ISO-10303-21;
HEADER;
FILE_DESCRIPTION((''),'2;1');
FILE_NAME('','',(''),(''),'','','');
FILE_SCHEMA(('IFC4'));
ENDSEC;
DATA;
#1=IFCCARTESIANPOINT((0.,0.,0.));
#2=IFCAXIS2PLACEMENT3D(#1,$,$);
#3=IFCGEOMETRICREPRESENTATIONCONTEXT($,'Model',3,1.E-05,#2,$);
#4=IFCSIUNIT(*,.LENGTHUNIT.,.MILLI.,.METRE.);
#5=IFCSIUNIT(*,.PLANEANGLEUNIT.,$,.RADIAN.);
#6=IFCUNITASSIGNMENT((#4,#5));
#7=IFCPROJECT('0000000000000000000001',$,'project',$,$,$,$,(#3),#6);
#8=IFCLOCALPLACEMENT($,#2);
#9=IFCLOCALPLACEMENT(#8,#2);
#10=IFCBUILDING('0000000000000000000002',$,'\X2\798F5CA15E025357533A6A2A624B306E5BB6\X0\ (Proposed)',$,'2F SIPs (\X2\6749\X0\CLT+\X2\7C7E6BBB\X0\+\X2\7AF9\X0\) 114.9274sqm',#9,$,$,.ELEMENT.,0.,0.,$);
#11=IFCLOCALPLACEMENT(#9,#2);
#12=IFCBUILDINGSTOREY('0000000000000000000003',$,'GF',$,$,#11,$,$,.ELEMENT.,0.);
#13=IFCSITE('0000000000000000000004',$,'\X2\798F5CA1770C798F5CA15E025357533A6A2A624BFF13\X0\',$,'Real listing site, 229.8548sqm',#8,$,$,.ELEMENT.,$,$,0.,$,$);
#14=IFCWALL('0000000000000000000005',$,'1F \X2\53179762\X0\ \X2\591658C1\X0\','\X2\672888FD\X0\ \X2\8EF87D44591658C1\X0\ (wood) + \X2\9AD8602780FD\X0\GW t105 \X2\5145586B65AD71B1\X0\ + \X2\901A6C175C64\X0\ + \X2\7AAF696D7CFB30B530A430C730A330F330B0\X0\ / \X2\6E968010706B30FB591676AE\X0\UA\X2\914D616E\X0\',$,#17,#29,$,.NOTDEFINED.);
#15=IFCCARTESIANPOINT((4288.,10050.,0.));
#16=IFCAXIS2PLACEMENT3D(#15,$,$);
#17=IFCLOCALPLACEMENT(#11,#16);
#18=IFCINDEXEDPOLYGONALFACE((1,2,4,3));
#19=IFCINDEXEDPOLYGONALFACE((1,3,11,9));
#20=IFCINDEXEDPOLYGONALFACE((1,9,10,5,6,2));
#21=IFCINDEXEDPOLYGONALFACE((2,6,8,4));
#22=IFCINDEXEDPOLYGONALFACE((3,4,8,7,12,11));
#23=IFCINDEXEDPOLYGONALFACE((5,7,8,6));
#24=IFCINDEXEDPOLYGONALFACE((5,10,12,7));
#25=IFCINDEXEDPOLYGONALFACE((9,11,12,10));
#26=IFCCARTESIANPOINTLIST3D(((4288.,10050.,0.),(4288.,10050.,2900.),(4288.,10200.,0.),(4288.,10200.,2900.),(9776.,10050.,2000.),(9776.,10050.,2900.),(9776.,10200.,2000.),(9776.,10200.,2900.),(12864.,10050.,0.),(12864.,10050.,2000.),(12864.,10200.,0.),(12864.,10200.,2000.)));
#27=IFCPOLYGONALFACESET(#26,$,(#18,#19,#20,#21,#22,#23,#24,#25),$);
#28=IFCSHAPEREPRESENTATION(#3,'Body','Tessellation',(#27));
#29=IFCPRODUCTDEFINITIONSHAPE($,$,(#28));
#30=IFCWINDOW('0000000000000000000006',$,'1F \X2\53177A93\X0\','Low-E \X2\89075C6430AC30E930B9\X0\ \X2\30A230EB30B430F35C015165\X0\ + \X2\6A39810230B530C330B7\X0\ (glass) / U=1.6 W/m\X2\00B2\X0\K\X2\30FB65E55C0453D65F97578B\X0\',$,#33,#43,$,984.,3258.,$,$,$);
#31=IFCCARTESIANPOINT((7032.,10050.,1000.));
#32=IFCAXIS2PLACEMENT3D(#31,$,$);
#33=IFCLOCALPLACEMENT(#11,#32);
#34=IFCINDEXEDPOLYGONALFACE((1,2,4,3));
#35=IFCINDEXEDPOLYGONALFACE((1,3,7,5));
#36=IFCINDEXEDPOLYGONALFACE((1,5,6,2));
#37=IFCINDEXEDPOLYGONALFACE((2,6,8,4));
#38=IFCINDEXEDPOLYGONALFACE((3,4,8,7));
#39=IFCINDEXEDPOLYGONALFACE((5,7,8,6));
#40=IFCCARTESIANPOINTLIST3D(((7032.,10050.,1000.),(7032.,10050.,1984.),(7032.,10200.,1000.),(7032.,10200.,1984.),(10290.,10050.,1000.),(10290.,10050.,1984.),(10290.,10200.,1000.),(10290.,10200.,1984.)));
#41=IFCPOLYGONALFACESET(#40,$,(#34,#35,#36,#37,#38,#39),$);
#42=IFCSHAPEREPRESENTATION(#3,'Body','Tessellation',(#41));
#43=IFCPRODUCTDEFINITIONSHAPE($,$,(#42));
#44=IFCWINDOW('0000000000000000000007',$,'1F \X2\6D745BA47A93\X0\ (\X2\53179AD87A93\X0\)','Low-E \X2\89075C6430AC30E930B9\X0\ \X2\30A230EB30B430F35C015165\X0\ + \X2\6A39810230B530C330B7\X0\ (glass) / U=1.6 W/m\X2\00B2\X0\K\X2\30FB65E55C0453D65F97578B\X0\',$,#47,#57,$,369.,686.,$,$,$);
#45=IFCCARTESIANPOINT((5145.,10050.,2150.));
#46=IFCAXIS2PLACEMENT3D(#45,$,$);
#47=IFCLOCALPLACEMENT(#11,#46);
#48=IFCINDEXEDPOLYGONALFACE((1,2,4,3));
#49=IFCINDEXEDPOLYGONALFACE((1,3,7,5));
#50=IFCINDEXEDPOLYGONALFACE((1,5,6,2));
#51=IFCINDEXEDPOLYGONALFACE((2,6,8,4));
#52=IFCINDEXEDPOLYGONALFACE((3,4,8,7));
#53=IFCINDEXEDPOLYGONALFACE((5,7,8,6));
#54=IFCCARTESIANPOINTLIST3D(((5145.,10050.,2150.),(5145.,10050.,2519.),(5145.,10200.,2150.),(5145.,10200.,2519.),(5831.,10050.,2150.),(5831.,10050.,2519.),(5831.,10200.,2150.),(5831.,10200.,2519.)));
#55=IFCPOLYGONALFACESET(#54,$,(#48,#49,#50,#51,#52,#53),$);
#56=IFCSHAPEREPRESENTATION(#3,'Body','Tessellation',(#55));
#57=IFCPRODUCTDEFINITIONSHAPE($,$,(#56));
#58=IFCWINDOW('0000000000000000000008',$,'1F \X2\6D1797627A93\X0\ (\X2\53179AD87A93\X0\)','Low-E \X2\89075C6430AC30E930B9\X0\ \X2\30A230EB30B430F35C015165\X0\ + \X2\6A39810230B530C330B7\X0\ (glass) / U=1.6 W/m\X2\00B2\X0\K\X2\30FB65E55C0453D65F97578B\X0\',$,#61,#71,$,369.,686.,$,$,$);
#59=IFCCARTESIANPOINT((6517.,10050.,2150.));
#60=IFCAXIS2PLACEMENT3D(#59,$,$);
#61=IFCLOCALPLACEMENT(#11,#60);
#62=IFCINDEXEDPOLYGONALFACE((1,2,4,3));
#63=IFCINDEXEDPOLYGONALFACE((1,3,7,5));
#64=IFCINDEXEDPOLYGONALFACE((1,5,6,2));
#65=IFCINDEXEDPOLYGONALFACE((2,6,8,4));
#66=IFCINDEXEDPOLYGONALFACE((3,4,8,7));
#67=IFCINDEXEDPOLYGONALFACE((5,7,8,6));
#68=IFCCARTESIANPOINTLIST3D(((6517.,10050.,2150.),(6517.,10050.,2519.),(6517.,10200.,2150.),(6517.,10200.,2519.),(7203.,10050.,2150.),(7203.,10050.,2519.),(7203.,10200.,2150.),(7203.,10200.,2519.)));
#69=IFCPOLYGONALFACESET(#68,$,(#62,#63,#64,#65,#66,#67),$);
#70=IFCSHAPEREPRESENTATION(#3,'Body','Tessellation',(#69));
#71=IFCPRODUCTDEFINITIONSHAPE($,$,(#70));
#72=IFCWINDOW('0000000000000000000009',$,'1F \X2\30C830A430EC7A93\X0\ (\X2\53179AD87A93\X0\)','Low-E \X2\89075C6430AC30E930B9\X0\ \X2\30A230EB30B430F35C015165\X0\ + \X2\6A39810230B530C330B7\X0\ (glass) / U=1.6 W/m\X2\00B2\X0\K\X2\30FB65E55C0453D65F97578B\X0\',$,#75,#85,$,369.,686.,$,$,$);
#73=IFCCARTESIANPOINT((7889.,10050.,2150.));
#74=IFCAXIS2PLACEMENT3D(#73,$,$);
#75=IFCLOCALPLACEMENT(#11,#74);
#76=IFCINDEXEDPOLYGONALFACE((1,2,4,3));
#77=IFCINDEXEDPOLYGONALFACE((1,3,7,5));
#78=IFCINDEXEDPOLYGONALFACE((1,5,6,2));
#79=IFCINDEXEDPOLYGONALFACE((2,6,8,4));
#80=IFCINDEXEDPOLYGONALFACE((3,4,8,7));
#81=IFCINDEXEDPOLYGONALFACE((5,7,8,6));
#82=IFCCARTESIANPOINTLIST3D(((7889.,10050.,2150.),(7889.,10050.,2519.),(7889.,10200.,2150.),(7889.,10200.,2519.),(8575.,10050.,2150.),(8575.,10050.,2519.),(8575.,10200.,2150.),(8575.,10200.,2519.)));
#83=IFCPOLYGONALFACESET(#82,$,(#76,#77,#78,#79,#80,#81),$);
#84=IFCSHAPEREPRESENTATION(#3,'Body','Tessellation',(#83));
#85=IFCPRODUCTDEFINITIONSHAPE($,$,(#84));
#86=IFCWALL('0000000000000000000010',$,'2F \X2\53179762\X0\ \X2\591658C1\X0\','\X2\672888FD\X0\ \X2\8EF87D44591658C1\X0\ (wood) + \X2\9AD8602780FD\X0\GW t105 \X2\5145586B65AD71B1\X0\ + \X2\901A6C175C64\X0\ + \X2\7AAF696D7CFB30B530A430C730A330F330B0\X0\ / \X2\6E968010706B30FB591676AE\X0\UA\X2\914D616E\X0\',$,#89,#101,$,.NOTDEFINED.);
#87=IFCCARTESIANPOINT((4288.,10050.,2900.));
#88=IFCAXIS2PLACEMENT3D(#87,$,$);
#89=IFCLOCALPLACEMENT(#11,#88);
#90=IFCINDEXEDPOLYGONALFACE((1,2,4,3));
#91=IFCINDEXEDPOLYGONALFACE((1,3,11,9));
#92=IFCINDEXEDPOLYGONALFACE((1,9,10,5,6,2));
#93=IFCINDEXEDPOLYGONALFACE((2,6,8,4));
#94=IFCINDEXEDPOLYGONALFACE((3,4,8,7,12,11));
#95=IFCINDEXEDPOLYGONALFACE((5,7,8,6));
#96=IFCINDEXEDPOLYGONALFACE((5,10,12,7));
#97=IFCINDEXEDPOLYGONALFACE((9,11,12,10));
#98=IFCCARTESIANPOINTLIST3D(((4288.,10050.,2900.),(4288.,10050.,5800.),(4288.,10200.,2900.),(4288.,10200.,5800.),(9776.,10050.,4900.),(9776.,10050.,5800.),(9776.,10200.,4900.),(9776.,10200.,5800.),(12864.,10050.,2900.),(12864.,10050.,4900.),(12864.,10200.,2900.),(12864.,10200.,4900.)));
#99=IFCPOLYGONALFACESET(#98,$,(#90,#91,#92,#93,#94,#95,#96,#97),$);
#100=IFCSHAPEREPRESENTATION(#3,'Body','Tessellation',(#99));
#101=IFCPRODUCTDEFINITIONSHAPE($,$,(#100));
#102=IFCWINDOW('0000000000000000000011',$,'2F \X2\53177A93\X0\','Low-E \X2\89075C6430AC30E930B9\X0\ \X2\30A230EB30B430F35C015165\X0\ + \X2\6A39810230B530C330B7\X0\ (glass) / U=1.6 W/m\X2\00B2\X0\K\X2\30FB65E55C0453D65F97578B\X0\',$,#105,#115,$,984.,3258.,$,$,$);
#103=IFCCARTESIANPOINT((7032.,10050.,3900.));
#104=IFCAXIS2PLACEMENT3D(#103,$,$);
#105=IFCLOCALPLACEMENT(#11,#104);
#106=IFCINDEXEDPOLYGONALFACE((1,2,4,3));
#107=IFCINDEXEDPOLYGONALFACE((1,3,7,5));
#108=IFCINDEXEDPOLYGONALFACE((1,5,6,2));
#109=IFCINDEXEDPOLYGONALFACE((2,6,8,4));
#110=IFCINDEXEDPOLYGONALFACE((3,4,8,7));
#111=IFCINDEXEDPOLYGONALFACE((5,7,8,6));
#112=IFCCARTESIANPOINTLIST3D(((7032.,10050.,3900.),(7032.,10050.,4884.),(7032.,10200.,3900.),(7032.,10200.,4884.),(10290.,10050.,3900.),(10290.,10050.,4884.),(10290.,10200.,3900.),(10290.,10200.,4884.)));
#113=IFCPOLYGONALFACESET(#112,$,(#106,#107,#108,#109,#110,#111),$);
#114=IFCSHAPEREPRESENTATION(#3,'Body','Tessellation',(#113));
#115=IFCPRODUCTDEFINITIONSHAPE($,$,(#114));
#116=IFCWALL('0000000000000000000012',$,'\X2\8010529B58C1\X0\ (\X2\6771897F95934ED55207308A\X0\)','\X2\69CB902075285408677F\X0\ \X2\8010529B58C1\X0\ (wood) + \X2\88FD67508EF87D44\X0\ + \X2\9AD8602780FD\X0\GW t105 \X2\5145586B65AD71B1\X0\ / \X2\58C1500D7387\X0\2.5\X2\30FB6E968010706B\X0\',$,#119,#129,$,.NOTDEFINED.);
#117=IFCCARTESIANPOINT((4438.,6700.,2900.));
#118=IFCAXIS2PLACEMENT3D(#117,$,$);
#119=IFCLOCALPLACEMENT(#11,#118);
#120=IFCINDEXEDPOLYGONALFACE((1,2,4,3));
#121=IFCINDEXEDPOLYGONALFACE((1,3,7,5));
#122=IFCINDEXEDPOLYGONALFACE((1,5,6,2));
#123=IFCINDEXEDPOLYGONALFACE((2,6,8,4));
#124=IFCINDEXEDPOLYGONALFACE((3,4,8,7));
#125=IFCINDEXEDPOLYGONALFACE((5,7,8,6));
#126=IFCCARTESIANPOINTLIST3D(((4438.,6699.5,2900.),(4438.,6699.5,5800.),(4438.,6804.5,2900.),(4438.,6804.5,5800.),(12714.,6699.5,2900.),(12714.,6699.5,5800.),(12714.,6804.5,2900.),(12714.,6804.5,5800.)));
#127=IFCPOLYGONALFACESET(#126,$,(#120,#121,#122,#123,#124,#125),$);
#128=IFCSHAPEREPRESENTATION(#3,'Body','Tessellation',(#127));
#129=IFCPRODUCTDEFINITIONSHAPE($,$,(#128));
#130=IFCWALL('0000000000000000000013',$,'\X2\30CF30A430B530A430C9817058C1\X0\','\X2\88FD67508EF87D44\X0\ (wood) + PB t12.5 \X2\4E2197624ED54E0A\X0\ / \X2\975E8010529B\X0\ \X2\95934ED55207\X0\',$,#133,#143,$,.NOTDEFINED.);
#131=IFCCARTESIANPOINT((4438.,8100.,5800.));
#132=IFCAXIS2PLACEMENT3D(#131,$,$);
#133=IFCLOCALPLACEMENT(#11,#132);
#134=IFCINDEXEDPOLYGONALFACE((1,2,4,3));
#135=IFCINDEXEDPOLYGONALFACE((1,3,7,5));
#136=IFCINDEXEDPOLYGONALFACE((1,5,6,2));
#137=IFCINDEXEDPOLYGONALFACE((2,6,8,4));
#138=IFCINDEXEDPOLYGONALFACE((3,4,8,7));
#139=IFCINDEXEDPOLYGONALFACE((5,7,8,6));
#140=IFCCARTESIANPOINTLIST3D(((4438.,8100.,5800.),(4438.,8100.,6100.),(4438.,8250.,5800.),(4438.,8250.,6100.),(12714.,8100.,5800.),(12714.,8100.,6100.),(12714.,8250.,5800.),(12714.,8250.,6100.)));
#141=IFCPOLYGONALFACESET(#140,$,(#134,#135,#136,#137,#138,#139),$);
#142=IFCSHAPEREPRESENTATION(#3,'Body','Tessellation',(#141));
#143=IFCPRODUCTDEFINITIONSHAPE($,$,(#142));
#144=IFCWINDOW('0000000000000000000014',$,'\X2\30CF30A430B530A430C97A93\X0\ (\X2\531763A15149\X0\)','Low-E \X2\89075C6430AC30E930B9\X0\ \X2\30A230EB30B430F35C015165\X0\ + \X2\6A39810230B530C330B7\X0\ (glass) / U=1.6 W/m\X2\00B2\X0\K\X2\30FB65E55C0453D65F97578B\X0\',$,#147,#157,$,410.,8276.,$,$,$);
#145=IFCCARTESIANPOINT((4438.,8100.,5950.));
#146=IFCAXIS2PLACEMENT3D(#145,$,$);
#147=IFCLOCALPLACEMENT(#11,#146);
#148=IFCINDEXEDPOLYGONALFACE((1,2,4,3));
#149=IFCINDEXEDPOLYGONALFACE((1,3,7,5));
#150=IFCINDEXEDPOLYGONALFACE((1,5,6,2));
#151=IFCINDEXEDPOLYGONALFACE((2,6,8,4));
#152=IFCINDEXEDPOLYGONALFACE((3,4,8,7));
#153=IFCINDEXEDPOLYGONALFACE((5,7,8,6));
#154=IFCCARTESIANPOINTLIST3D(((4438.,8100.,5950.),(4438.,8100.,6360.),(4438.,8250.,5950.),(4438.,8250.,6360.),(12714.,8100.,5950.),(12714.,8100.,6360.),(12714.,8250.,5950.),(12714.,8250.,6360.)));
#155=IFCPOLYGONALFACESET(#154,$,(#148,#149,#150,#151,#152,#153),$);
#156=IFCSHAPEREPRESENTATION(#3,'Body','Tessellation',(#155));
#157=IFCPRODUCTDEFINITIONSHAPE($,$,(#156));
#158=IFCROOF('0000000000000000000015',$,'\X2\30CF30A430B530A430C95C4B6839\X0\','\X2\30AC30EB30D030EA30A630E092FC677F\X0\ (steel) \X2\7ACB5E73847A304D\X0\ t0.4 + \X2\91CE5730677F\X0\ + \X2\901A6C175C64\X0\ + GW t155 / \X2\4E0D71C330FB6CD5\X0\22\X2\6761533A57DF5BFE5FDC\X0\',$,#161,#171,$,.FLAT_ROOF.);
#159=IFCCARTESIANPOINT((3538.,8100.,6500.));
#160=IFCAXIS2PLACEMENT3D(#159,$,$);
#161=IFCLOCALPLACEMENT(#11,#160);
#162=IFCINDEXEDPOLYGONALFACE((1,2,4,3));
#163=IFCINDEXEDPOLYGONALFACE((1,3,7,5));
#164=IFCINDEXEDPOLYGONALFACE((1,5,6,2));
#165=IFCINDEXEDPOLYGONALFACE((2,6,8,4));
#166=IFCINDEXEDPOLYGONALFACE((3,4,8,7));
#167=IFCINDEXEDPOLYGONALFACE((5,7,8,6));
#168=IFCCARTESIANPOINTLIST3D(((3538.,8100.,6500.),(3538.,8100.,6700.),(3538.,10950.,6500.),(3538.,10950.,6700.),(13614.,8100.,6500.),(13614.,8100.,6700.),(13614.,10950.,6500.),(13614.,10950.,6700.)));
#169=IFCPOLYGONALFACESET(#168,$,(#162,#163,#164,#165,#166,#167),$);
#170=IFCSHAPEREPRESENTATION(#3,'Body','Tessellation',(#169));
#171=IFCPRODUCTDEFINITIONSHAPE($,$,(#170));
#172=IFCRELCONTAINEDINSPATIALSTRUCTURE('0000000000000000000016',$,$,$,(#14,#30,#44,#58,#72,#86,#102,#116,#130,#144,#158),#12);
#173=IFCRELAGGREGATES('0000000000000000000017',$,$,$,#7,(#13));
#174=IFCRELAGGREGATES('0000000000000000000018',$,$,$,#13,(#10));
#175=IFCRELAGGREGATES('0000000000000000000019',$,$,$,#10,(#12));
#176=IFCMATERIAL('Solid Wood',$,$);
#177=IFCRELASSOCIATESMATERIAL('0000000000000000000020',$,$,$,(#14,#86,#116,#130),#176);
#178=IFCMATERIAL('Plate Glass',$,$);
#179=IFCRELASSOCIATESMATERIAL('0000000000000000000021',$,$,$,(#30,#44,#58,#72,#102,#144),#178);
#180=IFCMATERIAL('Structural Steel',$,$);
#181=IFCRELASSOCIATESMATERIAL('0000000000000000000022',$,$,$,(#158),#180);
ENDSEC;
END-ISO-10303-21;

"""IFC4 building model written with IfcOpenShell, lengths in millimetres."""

from ifc_helpers import new_model, si_unit, frame, frame_2d, origin, place, context, project, spatial, rectangle, extrude, material, element, fill, save


model = new_model("IFC4")

# Units and contexts
model_context = context("Model", 3, precision=1e-05, world=origin())
ifc_project = project(units=[si_unit("LENGTHUNIT", "METRE", prefix="MILLI"), si_unit("PLANEANGLEUNIT", "RADIAN")], contexts=[model_context])

# Site, building, storey
site_placement = place(None, origin())
site = spatial("IfcSite", under=ifc_project, at=site_placement, Name="福岡県福岡市南区横手３", ObjectType="Real listing site, 229.8548sqm", CompositionType="ELEMENT", RefElevation=0.0)
building_placement = place(site_placement, origin())
building = spatial("IfcBuilding", under=site, at=building_placement, Name="福岡市南区横手の家 (Proposed)", ObjectType="2F SIPs (杉CLT+籾殻+竹) 114.9274sqm", CompositionType="ELEMENT", ElevationOfRefHeight=0.0, ElevationOfTerrain=0.0)
storey_placement = place(building_placement, origin())
storey = spatial("IfcBuildingStorey", under=building, at=storey_placement, Name="GF", CompositionType="ELEMENT", Elevation=0.0)

# Wall, openings, windows
ifc_material_1 = material(Name="Solid Wood")
wall_1_placement = place(storey_placement, frame((4288.0, 10050.0, 0.0)))
wall_1 = element("IfcWall", 1, at=wall_1_placement, inside=storey, material=ifc_material_1, Name="1F 北面 外壁", Description="木製 軸組外壁 (wood) + 高性能GW t105 充填断熱 + 通気層 + 窯業系サイディング / 準耐火・外皮UA配慮", PredefinedType="NOTDEFINED", context=model_context, shape_type="SweptSolid", body=[
    extrude(rectangle(XDim=8576.0, YDim=150.0, at=frame_2d((4288.0, 75.0))), frame((4288.0, 10050.0, 0.0)), (0.0, 0.0, 1.0), 2900.0),
])
opening_1_placement = place(storey_placement, frame((7032.0, 10050.0, 1000.0)))
opening_1 = element("IfcOpeningElement", 2, at=opening_1_placement, cuts=wall_1, PredefinedType="NOTDEFINED", context=model_context, shape_type="SweptSolid", body=[
    extrude(rectangle(XDim=3258.0, YDim=150.0, at=frame_2d((1629.0, 75.0))), frame((7032.0, 10050.0, 1000.0)), (0.0, 0.0, 1.0), 984.0),
])
opening_2_placement = place(storey_placement, frame((5145.0, 10050.0, 2150.0)))
opening_2 = element("IfcOpeningElement", 3, at=opening_2_placement, cuts=wall_1, PredefinedType="NOTDEFINED", context=model_context, shape_type="SweptSolid", body=[
    extrude(rectangle(XDim=686.0, YDim=150.0, at=frame_2d((343.0, 75.0))), frame((5145.0, 10050.0, 2150.0)), (0.0, 0.0, 1.0), 369.0),
])
opening_3_placement = place(storey_placement, frame((6517.0, 10050.0, 2150.0)))
opening_3 = element("IfcOpeningElement", 4, at=opening_3_placement, cuts=wall_1, PredefinedType="NOTDEFINED", context=model_context, shape_type="SweptSolid", body=[
    extrude(rectangle(XDim=686.0, YDim=150.0, at=frame_2d((343.0, 75.0))), frame((6517.0, 10050.0, 2150.0)), (0.0, 0.0, 1.0), 369.0),
])
opening_4_placement = place(storey_placement, frame((7889.0, 10050.0, 2150.0)))
opening_4 = element("IfcOpeningElement", 5, at=opening_4_placement, cuts=wall_1, PredefinedType="NOTDEFINED", context=model_context, shape_type="SweptSolid", body=[
    extrude(rectangle(XDim=686.0, YDim=150.0, at=frame_2d((343.0, 75.0))), frame((7889.0, 10050.0, 2150.0)), (0.0, 0.0, 1.0), 369.0),
])
ifc_material_2 = material(Name="Plate Glass")
window_1_placement = place(storey_placement, frame((7032.0, 10050.0, 1000.0)))
window_1 = element("IfcWindow", 6, at=window_1_placement, inside=storey, material=ifc_material_2, Name="1F 北窓", Description="Low-E 複層ガラス アルゴン封入 + 樹脂サッシ (glass) / U=1.6 W/m²K・日射取得型", OverallHeight=984.0, OverallWidth=3258.0, context=model_context, shape_type="SweptSolid", body=[
    extrude(rectangle(XDim=3258.0, YDim=150.0, at=frame_2d((1629.0, 75.0))), frame((7032.0, 10050.0, 1000.0)), (0.0, 0.0, 1.0), 984.0),
])
fill(opening_1, window_1)
window_2_placement = place(storey_placement, frame((5145.0, 10050.0, 2150.0)))
window_2 = element("IfcWindow", 7, at=window_2_placement, inside=storey, material=ifc_material_2, Name="1F 浴室窓 (北高窓)", Description="Low-E 複層ガラス アルゴン封入 + 樹脂サッシ (glass) / U=1.6 W/m²K・日射取得型", OverallHeight=369.0, OverallWidth=686.0, context=model_context, shape_type="SweptSolid", body=[
    extrude(rectangle(XDim=686.0, YDim=150.0, at=frame_2d((343.0, 75.0))), frame((5145.0, 10050.0, 2150.0)), (0.0, 0.0, 1.0), 369.0),
])
fill(opening_2, window_2)
window_3_placement = place(storey_placement, frame((6517.0, 10050.0, 2150.0)))
window_3 = element("IfcWindow", 8, at=window_3_placement, inside=storey, material=ifc_material_2, Name="1F 洗面窓 (北高窓)", Description="Low-E 複層ガラス アルゴン封入 + 樹脂サッシ (glass) / U=1.6 W/m²K・日射取得型", OverallHeight=369.0, OverallWidth=686.0, context=model_context, shape_type="SweptSolid", body=[
    extrude(rectangle(XDim=686.0, YDim=150.0, at=frame_2d((343.0, 75.0))), frame((6517.0, 10050.0, 2150.0)), (0.0, 0.0, 1.0), 369.0),
])
fill(opening_3, window_3)
window_4_placement = place(storey_placement, frame((7889.0, 10050.0, 2150.0)))
window_4 = element("IfcWindow", 9, at=window_4_placement, inside=storey, material=ifc_material_2, Name="1F トイレ窓 (北高窓)", Description="Low-E 複層ガラス アルゴン封入 + 樹脂サッシ (glass) / U=1.6 W/m²K・日射取得型", OverallHeight=369.0, OverallWidth=686.0, context=model_context, shape_type="SweptSolid", body=[
    extrude(rectangle(XDim=686.0, YDim=150.0, at=frame_2d((343.0, 75.0))), frame((7889.0, 10050.0, 2150.0)), (0.0, 0.0, 1.0), 369.0),
])
fill(opening_4, window_4)

# Wall, opening, window
wall_2_placement = place(storey_placement, frame((4288.0, 10050.0, 2900.0)))
wall_2 = element("IfcWall", 10, at=wall_2_placement, inside=storey, material=ifc_material_1, Name="2F 北面 外壁", Description="木製 軸組外壁 (wood) + 高性能GW t105 充填断熱 + 通気層 + 窯業系サイディング / 準耐火・外皮UA配慮", PredefinedType="NOTDEFINED", context=model_context, shape_type="SweptSolid", body=[
    extrude(rectangle(XDim=8576.0, YDim=150.0, at=frame_2d((4288.0, 75.0))), frame((4288.0, 10050.0, 2900.0)), (0.0, 0.0, 1.0), 2900.0),
])
opening_5_placement = place(storey_placement, frame((7032.0, 10050.0, 3900.0)))
opening_5 = element("IfcOpeningElement", 11, at=opening_5_placement, cuts=wall_2, PredefinedType="NOTDEFINED", context=model_context, shape_type="SweptSolid", body=[
    extrude(rectangle(XDim=3258.0, YDim=150.0, at=frame_2d((1629.0, 75.0))), frame((7032.0, 10050.0, 3900.0)), (0.0, 0.0, 1.0), 984.0),
])
window_5_placement = place(storey_placement, frame((7032.0, 10050.0, 3900.0)))
window_5 = element("IfcWindow", 12, at=window_5_placement, inside=storey, material=ifc_material_2, Name="2F 北窓", Description="Low-E 複層ガラス アルゴン封入 + 樹脂サッシ (glass) / U=1.6 W/m²K・日射取得型", OverallHeight=984.0, OverallWidth=3258.0, context=model_context, shape_type="SweptSolid", body=[
    extrude(rectangle(XDim=3258.0, YDim=150.0, at=frame_2d((1629.0, 75.0))), frame((7032.0, 10050.0, 3900.0)), (0.0, 0.0, 1.0), 984.0),
])
fill(opening_5, window_5)

# Wall
wall_3_placement = place(storey_placement, frame((4438.0, 6700.0, 2900.0)))
element("IfcWall", 13, at=wall_3_placement, inside=storey, material=ifc_material_1, Name="耐力壁 (東西間仕切り)", Description="構造用合板 耐力壁 (wood) + 製材軸組 + 高性能GW t105 充填断熱 / 壁倍率2.5・準耐火", PredefinedType="NOTDEFINED", context=model_context, shape_type="SweptSolid", body=[
    extrude(rectangle(XDim=8276.0, YDim=105.0, at=frame_2d((4138.0, 52.0))), frame((4438.0, 6700.0, 2900.0)), (0.0, 0.0, 1.0), 2900.0),
])

# Wall, opening, window
wall_4_placement = place(storey_placement, frame((4438.0, 8100.0, 5800.0)))
wall_4 = element("IfcWall", 14, at=wall_4_placement, inside=storey, material=ifc_material_1, Name="ハイサイド腰壁", Description="製材軸組 (wood) + PB t12.5 両面仕上 / 非耐力 間仕切", PredefinedType="NOTDEFINED", context=model_context, shape_type="SweptSolid", body=[
    extrude(rectangle(XDim=8276.0, YDim=150.0, at=frame_2d((4138.0, 75.0))), frame((4438.0, 8100.0, 5800.0)), (0.0, 0.0, 1.0), 700.0),
])
opening_6_placement = place(storey_placement, frame((4438.0, 8100.0, 5950.0)))
opening_6 = element("IfcOpeningElement", 15, at=opening_6_placement, cuts=wall_4, PredefinedType="NOTDEFINED", context=model_context, shape_type="SweptSolid", body=[
    extrude(rectangle(XDim=8276.0, YDim=150.0, at=frame_2d((4138.0, 75.0))), frame((4438.0, 8100.0, 5950.0)), (0.0, 0.0, 1.0), 410.0),
])
window_6_placement = place(storey_placement, frame((4438.0, 8100.0, 5950.0)))
window_6 = element("IfcWindow", 16, at=window_6_placement, inside=storey, material=ifc_material_2, Name="ハイサイド窓 (北採光)", Description="Low-E 複層ガラス アルゴン封入 + 樹脂サッシ (glass) / U=1.6 W/m²K・日射取得型", OverallHeight=410.0, OverallWidth=8276.0, context=model_context, shape_type="SweptSolid", body=[
    extrude(rectangle(XDim=8276.0, YDim=150.0, at=frame_2d((4138.0, 75.0))), frame((4438.0, 8100.0, 5950.0)), (0.0, 0.0, 1.0), 410.0),
])
fill(opening_6, window_6)

# Roof
ifc_material_3 = material(Name="Structural Steel")
roof_placement = place(storey_placement, frame((3538.0, 8100.0, 6500.0)))
element("IfcRoof", 17, at=roof_placement, inside=storey, material=ifc_material_3, Name="ハイサイド屋根", Description="ガルバリウム鋼板 (steel) 立平葺き t0.4 + 野地板 + 通気層 + GW t155 / 不燃・法22条区域対応", PredefinedType="FLAT_ROOF", context=model_context, shape_type="SweptSolid", body=[
    extrude(rectangle(XDim=10076.0, YDim=2850.0, at=frame_2d((5038.0, 1425.0))), frame((3538.0, 8100.0, 6500.0)), (0.0, 0.0, 1.0), 200.0),
])

save(model, "model.ifc")
